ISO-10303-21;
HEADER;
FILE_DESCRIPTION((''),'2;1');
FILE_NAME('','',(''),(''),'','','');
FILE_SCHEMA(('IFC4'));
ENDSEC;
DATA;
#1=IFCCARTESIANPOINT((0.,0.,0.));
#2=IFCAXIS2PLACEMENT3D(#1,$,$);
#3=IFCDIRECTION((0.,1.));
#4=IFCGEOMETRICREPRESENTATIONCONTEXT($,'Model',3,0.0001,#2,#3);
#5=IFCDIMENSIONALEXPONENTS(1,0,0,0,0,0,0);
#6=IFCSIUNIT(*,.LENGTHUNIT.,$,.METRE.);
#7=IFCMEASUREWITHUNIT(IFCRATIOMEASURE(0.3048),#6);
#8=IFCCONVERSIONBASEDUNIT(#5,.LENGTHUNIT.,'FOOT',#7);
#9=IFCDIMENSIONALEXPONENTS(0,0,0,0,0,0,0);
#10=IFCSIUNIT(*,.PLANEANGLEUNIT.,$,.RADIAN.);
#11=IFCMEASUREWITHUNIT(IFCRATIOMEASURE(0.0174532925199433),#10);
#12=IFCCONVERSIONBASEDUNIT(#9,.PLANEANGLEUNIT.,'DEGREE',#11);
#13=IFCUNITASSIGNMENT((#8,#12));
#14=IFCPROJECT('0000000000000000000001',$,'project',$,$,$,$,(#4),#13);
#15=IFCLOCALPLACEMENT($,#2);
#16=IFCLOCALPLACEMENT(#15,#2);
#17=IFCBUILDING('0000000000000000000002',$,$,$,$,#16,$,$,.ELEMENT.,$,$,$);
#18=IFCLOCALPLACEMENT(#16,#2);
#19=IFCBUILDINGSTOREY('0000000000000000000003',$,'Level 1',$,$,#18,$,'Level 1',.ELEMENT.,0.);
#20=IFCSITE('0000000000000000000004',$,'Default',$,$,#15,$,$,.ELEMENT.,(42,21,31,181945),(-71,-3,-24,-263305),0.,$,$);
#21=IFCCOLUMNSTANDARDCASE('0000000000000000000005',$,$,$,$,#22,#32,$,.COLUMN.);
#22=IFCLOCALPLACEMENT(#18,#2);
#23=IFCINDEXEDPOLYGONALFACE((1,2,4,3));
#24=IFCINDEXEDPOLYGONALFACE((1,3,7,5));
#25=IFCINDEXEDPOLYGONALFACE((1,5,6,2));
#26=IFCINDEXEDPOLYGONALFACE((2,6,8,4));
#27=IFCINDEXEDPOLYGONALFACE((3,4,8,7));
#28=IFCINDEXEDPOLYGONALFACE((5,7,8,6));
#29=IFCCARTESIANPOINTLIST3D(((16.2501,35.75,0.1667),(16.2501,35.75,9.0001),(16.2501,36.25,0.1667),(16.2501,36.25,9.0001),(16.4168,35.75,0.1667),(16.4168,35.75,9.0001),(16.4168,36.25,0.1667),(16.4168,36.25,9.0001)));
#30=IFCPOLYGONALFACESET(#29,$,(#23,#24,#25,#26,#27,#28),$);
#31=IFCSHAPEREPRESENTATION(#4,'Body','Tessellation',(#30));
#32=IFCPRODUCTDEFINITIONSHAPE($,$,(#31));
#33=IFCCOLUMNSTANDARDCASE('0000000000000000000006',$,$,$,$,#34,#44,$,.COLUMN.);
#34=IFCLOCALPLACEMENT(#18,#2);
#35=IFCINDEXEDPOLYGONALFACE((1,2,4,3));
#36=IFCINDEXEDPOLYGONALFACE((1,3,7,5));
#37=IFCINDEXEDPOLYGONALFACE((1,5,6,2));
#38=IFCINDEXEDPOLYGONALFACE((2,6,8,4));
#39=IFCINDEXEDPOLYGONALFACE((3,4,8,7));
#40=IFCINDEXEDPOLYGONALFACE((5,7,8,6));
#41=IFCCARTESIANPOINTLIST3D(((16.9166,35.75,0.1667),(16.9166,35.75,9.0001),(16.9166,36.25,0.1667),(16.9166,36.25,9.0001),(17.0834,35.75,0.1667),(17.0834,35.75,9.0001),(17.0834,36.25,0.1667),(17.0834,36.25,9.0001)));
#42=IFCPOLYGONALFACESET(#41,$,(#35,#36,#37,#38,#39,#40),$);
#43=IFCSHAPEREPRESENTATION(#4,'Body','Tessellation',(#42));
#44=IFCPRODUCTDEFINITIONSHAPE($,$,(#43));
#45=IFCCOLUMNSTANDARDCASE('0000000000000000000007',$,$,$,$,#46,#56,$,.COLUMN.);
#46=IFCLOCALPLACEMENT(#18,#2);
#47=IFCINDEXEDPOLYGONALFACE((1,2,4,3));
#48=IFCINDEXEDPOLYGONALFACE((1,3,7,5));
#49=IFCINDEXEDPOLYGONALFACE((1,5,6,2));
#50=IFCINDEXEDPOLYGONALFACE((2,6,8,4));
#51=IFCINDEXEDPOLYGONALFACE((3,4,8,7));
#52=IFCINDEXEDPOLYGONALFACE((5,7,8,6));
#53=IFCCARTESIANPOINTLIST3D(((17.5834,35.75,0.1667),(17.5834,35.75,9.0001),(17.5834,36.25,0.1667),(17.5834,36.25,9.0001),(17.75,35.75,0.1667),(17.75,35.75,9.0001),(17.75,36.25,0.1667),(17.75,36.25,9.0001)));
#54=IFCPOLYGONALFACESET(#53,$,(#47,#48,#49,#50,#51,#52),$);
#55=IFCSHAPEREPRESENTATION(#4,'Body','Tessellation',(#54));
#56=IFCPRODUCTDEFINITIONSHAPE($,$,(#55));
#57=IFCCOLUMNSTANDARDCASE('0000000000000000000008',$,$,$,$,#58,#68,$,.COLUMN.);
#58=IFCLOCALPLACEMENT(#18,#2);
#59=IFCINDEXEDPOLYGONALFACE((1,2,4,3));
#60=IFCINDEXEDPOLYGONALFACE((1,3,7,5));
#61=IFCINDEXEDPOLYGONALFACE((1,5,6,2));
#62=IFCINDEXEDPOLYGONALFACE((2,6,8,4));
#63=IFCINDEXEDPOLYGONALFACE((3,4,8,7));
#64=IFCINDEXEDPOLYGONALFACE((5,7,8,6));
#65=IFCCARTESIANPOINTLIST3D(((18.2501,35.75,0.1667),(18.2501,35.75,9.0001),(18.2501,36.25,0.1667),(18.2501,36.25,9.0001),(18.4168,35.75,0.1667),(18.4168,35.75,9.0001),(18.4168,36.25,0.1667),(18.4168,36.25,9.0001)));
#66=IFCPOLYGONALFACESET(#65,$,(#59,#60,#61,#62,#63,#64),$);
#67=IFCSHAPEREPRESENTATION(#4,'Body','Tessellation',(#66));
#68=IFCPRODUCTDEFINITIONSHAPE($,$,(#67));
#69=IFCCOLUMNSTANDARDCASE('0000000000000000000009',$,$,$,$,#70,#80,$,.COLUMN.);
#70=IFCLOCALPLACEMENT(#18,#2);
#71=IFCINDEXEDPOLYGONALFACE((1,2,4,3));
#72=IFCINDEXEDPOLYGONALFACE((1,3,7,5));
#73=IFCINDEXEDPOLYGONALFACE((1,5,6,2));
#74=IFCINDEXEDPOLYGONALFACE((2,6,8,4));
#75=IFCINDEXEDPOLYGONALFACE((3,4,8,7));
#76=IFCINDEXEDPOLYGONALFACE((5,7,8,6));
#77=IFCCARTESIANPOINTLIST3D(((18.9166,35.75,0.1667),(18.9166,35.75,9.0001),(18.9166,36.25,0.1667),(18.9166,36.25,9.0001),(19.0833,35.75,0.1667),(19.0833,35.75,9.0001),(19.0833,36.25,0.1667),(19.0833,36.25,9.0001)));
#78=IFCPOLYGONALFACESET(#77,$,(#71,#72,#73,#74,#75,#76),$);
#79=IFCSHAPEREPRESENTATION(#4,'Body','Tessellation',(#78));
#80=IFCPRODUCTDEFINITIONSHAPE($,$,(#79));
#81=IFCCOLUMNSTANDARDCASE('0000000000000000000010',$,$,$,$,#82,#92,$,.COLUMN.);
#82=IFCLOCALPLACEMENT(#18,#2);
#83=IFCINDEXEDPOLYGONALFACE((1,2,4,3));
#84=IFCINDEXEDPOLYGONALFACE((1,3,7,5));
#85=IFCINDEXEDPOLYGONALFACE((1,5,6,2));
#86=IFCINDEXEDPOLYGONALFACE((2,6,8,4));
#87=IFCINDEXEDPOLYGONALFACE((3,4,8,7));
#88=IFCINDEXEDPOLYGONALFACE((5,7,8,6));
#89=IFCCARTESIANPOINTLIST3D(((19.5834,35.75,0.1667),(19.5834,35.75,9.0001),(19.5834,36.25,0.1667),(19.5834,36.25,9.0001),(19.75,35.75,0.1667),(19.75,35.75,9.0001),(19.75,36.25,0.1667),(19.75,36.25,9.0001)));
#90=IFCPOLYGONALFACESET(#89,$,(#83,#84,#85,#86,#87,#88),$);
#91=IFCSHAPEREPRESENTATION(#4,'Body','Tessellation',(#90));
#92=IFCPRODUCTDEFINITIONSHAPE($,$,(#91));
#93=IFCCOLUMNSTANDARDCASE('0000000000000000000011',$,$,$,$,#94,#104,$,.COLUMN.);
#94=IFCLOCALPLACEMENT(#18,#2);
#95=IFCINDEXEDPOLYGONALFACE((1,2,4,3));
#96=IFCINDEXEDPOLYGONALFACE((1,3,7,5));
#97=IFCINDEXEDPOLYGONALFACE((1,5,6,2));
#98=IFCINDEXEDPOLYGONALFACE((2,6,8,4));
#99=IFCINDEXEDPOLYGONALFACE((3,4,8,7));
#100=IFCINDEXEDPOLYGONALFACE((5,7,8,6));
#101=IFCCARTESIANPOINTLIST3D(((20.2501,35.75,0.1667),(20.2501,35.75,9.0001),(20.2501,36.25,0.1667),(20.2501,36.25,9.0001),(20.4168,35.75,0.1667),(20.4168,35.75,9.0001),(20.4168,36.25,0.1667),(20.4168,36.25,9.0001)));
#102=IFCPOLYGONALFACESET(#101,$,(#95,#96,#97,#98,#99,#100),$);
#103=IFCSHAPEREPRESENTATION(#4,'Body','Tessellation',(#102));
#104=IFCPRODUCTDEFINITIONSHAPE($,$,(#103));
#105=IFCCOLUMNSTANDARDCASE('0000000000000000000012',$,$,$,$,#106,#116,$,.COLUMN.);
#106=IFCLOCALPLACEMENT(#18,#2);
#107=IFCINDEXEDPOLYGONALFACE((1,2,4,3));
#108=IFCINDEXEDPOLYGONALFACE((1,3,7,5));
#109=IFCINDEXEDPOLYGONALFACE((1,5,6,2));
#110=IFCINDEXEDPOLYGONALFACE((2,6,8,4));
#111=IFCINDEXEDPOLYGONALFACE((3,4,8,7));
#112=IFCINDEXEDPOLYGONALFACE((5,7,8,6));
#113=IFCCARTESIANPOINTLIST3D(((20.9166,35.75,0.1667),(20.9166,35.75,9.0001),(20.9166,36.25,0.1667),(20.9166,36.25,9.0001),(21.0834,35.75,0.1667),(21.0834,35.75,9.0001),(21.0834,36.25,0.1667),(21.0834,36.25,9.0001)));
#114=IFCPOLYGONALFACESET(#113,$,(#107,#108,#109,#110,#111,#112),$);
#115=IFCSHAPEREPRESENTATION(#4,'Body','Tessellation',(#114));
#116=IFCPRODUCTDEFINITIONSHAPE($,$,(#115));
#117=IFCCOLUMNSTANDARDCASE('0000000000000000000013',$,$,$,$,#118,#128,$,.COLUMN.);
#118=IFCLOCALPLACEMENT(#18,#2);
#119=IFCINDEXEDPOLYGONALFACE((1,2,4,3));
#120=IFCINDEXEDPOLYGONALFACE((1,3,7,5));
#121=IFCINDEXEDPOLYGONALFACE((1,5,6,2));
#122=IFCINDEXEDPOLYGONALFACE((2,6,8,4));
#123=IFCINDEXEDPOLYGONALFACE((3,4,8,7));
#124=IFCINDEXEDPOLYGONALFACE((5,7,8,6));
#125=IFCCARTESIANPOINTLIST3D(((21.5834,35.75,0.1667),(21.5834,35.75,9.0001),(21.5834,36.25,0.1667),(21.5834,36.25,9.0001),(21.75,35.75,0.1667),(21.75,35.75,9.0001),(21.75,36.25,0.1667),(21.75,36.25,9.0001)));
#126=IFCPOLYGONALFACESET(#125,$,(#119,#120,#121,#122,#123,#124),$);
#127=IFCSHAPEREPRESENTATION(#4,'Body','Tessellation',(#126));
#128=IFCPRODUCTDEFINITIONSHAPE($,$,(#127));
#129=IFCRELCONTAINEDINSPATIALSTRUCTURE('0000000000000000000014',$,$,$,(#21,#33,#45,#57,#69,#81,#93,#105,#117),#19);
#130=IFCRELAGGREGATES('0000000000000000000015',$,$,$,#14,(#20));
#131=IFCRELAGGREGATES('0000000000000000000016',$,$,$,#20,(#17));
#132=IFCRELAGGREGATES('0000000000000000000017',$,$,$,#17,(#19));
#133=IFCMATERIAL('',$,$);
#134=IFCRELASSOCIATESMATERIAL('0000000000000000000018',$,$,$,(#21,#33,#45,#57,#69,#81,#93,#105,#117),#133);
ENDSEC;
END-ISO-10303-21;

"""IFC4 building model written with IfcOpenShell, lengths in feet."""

from ifc_helpers import new_model, entity, si_unit, converted_unit, direction, frame, origin, place, context, project, spatial, rectangle, extrude, material, element, save


model = new_model("IFC4")

# Units and contexts
model_context = context("Model", 3, precision=0.0001, world=origin(), true_north=direction((0.0, 1.0)))
ifc_project = project(units=[converted_unit("LENGTHUNIT", "FOOT", entity("IfcRatioMeasure", 0.3048), si_unit("LENGTHUNIT", "METRE"), dimensions=[1, 0, 0, 0, 0, 0, 0]), converted_unit("PLANEANGLEUNIT", "DEGREE", entity("IfcRatioMeasure", 0.0174532925199433), si_unit("PLANEANGLEUNIT", "RADIAN"), dimensions=[0, 0, 0, 0, 0, 0, 0])], contexts=[model_context])

# Site, building, storey
site_placement = place(None, origin())
site = spatial("IfcSite", under=ifc_project, at=site_placement, Name="Default", CompositionType="ELEMENT", RefLatitude=(42, 21, 31, 181945), RefLongitude=(-71, -3, -24, -263305), RefElevation=0.0)
building_placement = place(site_placement, origin())
building = spatial("IfcBuilding", under=site, at=building_placement, CompositionType="ELEMENT")
storey_placement = place(building_placement, origin())
storey = spatial("IfcBuildingStorey", under=building, at=storey_placement, Name="Level 1", LongName="Level 1", CompositionType="ELEMENT", Elevation=0.0)

# Columns
ifc_material_1 = material(Name="")
placement_1 = place(storey_placement, frame((0.25, 36.0, 0.0)))
for number, where, z_axis, x_axis in (
    (1, (16.0834, 0.0, 0.1667), (0.0, 0.0, 1.0), (1.0, 0.0, 0.0)),
    (2, (16.75, 0.0, 0.1667), (0.0, 0.0, 1.0), (1.0, 0.0, 0.0)),
    (3, (17.4167, 0.0, 0.1667), (0.0, 0.0, 1.0), (1.0, 0.0, 0.0)),
    (4, (18.0834, 0.0, 0.1667), (0.0, 0.0, 1.0), (1.0, 0.0, 0.0)),
    (5, (18.75, 0.0, 0.1667), (0.0, 0.0, 1.0), (1.0, 0.0, 0.0)),
    (6, (19.4167, 0.0, 0.1667), (0.0, 0.0, 1.0), (1.0, 0.0, 0.0)),
    (7, (20.0834, 0.0, 0.1667), (0.0, 0.0, 1.0), (1.0, 0.0, 0.0)),
    (8, (20.75, 0.0, 0.1667), (0.0, 0.0, 1.0), (1.0, 0.0, 0.0)),
    (9, (21.4167, 0.0, 0.1667), (0.0, 0.0, 1.0), (1.0, 0.0, 0.0)),
):
    element("IfcColumnStandardCase", number, at=place(placement_1, frame(where, z_axis=z_axis, x_axis=x_axis)), inside=storey, material=ifc_material_1, PredefinedType="COLUMN", context=model_context, shape_type="SweptSolid", body=[
        extrude(rectangle(XDim=0.1667, YDim=0.5), origin(), (0.0, 0.0, 1.0), 8.8334),
    ])

save(model, "model.ifc")
